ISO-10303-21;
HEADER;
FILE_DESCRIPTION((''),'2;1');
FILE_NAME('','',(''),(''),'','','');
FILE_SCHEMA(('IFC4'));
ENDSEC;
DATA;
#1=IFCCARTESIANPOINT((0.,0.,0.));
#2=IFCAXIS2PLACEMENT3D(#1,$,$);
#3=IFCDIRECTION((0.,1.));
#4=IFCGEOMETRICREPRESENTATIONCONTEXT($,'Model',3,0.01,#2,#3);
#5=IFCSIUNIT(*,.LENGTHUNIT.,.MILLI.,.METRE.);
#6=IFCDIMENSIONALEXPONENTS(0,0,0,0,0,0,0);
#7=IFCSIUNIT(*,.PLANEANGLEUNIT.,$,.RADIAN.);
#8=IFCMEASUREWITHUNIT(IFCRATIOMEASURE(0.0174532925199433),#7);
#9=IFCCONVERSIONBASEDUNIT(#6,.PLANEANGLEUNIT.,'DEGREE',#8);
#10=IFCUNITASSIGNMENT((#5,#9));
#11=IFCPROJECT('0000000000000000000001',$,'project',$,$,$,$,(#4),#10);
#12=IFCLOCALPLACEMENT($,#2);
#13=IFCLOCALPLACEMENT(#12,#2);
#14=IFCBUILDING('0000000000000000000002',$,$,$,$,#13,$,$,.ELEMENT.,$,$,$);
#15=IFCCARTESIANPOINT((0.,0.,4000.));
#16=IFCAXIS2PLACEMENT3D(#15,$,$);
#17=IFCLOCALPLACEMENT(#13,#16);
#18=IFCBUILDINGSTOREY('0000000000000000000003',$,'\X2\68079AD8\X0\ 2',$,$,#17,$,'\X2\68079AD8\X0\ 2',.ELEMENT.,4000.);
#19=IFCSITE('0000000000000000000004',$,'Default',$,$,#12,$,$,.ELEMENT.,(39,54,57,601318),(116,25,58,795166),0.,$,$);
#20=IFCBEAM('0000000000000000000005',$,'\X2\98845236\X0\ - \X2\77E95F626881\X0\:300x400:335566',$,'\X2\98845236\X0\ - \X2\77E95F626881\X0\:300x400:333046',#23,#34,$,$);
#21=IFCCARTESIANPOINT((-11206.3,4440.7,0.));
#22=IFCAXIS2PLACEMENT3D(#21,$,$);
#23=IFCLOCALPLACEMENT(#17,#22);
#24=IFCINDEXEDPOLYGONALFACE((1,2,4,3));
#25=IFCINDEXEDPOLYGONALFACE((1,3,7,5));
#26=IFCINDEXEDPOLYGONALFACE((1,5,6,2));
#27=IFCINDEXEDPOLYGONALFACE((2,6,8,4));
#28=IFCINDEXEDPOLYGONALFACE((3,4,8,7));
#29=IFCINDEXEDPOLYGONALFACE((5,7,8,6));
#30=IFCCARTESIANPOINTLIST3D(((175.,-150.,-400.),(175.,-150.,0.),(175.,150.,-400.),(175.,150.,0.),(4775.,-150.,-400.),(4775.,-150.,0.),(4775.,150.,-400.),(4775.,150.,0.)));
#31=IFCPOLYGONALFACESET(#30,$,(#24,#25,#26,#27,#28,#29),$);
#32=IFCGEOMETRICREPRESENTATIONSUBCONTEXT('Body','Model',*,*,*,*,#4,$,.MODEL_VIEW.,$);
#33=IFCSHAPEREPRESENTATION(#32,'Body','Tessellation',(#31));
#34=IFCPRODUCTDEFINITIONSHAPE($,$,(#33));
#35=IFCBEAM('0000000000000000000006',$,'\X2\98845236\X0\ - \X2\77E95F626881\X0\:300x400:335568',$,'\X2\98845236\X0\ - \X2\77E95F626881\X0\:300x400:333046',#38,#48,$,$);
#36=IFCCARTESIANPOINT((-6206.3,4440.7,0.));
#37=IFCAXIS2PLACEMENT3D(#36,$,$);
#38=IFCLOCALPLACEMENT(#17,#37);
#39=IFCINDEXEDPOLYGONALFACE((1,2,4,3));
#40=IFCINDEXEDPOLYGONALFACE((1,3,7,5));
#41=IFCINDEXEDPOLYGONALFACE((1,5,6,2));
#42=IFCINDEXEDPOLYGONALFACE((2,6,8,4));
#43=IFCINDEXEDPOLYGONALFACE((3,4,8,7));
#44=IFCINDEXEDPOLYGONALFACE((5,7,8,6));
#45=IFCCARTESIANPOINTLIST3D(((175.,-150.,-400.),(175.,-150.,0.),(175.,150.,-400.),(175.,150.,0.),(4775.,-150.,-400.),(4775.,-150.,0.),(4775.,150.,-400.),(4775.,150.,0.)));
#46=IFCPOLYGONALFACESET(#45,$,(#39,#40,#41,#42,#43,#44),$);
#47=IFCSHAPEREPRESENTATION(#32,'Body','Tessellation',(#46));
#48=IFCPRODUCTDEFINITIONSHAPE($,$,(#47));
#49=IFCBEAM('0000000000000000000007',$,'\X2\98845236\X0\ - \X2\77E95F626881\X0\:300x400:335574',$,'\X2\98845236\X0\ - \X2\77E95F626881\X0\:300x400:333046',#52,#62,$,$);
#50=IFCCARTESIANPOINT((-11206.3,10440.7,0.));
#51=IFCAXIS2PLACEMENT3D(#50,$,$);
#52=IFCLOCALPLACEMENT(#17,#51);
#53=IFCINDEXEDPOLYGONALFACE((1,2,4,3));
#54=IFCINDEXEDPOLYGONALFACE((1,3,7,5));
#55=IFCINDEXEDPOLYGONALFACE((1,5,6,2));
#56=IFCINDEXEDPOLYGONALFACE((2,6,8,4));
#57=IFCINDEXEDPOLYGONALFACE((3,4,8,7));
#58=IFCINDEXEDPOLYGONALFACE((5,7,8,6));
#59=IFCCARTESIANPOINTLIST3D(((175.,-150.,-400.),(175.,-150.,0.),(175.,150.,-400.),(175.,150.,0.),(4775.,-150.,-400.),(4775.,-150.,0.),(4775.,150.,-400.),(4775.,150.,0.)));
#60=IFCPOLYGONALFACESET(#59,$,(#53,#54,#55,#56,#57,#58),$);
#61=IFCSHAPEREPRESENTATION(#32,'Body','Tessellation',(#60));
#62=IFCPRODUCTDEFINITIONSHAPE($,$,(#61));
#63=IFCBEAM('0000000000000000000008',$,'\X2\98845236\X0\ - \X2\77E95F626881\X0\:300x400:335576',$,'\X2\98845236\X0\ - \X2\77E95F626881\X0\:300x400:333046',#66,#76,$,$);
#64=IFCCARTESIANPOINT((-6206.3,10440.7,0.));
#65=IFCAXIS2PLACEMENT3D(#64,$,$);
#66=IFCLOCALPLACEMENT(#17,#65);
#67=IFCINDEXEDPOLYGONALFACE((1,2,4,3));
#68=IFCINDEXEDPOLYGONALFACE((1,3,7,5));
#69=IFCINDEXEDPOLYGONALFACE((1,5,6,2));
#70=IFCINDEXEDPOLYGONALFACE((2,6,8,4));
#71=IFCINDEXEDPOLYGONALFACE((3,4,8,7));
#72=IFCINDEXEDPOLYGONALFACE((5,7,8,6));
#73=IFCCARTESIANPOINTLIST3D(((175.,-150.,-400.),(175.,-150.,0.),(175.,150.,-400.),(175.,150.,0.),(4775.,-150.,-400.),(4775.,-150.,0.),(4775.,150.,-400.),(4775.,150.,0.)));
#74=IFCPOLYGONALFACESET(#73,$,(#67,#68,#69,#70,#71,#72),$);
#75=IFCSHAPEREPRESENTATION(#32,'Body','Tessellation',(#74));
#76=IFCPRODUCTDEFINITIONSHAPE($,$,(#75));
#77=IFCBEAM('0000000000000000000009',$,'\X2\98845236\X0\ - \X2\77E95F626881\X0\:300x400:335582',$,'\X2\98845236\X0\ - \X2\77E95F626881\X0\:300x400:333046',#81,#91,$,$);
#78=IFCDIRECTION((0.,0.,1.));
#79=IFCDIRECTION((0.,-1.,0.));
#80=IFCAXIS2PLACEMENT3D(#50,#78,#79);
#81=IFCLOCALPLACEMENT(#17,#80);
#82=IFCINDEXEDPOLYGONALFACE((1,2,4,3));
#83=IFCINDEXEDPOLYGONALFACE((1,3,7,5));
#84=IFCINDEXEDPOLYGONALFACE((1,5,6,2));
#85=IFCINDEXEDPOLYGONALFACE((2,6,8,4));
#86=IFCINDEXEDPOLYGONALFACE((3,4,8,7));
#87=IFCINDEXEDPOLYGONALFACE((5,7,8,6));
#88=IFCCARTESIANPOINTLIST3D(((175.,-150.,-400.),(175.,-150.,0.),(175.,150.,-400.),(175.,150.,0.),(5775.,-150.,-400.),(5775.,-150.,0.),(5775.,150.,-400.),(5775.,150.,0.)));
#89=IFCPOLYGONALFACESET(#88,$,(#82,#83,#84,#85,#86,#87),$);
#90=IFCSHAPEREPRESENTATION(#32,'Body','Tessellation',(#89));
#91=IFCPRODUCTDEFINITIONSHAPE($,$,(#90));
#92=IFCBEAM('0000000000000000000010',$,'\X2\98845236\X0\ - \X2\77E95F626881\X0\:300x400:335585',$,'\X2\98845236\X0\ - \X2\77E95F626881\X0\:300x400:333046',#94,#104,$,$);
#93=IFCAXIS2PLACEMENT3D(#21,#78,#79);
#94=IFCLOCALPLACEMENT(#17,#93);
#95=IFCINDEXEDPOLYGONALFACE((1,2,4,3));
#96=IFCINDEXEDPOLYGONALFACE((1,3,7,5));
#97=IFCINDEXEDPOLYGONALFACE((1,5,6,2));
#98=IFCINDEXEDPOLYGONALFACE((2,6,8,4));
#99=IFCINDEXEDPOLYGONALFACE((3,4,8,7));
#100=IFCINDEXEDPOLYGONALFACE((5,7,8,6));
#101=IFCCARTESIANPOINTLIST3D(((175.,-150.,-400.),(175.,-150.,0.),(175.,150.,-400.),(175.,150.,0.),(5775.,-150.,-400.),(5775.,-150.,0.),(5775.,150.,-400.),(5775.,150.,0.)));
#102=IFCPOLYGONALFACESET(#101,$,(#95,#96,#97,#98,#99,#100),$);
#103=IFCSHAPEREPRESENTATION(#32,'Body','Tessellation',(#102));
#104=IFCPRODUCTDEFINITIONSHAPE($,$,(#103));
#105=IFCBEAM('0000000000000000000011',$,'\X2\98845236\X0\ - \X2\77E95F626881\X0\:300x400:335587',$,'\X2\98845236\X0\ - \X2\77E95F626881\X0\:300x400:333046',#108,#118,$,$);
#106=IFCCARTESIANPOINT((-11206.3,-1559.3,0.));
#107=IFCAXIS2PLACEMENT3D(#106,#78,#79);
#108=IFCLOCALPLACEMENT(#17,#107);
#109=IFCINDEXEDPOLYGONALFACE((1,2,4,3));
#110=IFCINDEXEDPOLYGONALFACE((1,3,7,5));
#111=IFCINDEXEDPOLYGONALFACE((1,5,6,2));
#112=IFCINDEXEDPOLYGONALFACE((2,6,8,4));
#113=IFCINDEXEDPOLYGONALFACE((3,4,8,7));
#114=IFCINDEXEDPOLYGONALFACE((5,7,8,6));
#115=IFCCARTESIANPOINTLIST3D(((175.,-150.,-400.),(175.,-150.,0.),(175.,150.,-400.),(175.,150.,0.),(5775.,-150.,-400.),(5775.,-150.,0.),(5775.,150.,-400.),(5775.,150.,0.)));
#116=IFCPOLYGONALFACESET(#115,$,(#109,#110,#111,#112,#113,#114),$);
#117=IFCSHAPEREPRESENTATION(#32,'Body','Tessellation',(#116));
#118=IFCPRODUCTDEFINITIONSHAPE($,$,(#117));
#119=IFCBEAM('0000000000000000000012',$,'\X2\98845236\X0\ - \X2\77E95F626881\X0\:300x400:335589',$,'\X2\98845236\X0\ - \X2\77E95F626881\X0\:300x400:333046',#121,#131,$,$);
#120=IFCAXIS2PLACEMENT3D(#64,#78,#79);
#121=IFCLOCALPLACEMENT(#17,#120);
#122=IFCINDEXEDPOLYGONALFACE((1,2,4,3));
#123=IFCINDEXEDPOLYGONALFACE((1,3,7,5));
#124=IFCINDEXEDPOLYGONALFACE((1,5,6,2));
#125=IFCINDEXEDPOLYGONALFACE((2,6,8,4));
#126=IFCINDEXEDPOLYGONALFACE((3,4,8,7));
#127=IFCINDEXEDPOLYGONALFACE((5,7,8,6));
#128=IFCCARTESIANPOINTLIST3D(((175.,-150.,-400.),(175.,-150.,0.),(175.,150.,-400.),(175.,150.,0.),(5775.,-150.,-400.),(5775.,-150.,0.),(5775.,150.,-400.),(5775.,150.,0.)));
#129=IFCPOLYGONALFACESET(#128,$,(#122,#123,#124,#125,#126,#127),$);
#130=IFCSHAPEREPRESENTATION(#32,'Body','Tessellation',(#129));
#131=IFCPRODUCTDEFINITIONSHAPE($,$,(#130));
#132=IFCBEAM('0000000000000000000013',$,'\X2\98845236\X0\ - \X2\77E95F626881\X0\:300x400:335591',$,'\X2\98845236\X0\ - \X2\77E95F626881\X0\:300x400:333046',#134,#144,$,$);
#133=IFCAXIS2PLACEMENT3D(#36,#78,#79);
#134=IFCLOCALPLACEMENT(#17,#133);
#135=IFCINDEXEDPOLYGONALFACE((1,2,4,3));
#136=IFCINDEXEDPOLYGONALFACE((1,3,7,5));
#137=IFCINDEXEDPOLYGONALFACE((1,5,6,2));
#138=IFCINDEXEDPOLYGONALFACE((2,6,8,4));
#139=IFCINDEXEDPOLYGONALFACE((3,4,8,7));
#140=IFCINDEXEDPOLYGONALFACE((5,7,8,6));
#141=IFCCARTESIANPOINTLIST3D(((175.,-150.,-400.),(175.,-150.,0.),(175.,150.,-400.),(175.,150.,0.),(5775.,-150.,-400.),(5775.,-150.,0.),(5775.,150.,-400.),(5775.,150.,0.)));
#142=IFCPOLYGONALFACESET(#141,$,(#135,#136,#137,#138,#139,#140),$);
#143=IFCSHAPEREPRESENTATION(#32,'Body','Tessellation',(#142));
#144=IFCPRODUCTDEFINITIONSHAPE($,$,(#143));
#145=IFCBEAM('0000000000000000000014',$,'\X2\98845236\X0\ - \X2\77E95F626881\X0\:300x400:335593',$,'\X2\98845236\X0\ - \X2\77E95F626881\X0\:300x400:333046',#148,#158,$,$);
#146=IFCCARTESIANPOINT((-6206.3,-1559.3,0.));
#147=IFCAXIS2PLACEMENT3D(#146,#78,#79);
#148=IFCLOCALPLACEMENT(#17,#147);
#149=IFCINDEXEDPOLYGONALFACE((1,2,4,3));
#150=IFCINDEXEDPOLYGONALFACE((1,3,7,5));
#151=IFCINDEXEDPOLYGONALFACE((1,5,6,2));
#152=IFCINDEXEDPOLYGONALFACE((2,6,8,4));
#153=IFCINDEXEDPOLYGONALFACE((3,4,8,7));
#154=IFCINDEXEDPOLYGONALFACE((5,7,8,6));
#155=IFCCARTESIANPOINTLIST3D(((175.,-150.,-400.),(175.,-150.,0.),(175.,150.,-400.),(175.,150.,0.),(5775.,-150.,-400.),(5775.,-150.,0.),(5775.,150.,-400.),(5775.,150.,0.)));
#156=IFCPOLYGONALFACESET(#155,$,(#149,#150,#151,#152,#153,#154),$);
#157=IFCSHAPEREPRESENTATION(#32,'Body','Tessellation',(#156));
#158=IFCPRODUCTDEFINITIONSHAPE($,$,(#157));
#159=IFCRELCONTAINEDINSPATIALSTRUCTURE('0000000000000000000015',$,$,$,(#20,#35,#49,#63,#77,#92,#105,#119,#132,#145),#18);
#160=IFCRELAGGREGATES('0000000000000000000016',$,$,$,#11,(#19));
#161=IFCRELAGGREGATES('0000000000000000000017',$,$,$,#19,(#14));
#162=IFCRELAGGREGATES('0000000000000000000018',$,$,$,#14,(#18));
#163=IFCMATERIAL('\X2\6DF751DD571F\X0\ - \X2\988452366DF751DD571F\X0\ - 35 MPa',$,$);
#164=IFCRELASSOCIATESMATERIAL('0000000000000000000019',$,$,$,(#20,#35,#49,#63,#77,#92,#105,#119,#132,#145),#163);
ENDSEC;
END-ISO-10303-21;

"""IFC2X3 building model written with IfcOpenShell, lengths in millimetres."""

from ifc_helpers import new_model, entity, si_unit, converted_unit, direction, frame, frame_2d, origin, place, context, subcontext, project, spatial, rectangle, extrude, material, element, save


model = new_model("IFC2X3")

# Units and contexts
model_context = context("Model", 3, precision=0.01, world=origin(), true_north=direction((0.0, 1.0)))
body_context = subcontext(model_context, "Body", "Model", "MODEL_VIEW")
ifc_project = project(units=[si_unit("LENGTHUNIT", "METRE", prefix="MILLI"), converted_unit("PLANEANGLEUNIT", "DEGREE", entity("IfcRatioMeasure", 0.0174532925199433), si_unit("PLANEANGLEUNIT", "RADIAN"), dimensions=[0, 0, 0, 0, 0, 0, 0])], contexts=[model_context])

# Site, building, storey
site_placement = place(None, origin())
site = spatial("IfcSite", under=ifc_project, at=site_placement, Name="Default", CompositionType="ELEMENT", RefLatitude=(39, 54, 57, 601318), RefLongitude=(116, 25, 58, 795166), RefElevation=0.0)
building_placement = place(site_placement, origin())
building = spatial("IfcBuilding", under=site, at=building_placement, CompositionType="ELEMENT")
storey_placement = place(building_placement, frame((0.0, 0.0, 4000.0)))
storey = spatial("IfcBuildingStorey", under=building, at=storey_placement, Name="标高 2", LongName="标高 2", CompositionType="ELEMENT", Elevation=4000.0)

# Shared definitions
ifc_material = material(Name="混凝土 - 预制混凝土 - 35 MPa")

# Beams
beam_1_placement = place(storey_placement, frame((-11206.3, 4440.7, 0.0)))
element("IfcBeam", 1, at=beam_1_placement, inside=storey, material=ifc_material, Name="预制 - 矩形梁:300x400:335566", ObjectType="预制 - 矩形梁:300x400:333046", context=body_context, shape_type="SweptSolid", body=[
    extrude(rectangle(XDim=400.0, YDim=300.0, at=frame_2d((0.0, 0.0), x_axis=(1.0, 0.0))), frame((175.0, 0.0, -200.0), z_axis=(1.0, 0.0, 0.0), x_axis=(0.0, 0.0, -1.0)), (0.0, 0.0, 1.0), 4600.0),
])
beam_2_placement = place(storey_placement, frame((-6206.3, 4440.7, 0.0)))
element("IfcBeam", 2, at=beam_2_placement, inside=storey, material=ifc_material, Name="预制 - 矩形梁:300x400:335568", ObjectType="预制 - 矩形梁:300x400:333046", context=body_context, shape_type="SweptSolid", body=[
    extrude(rectangle(XDim=400.0, YDim=300.0, at=frame_2d((0.0, 0.0), x_axis=(1.0, 0.0))), frame((175.0, 0.0, -200.0), z_axis=(1.0, 0.0, 0.0), x_axis=(0.0, 0.0, -1.0)), (0.0, 0.0, 1.0), 4600.0),
])
beam_3_placement = place(storey_placement, frame((-11206.3, 10440.7, 0.0)))
element("IfcBeam", 3, at=beam_3_placement, inside=storey, material=ifc_material, Name="预制 - 矩形梁:300x400:335574", ObjectType="预制 - 矩形梁:300x400:333046", context=body_context, shape_type="SweptSolid", body=[
    extrude(rectangle(XDim=400.0, YDim=300.0, at=frame_2d((0.0, 0.0), x_axis=(1.0, 0.0))), frame((175.0, 0.0, -200.0), z_axis=(1.0, 0.0, 0.0), x_axis=(0.0, 0.0, -1.0)), (0.0, 0.0, 1.0), 4600.0),
])
beam_4_placement = place(storey_placement, frame((-6206.3, 10440.7, 0.0)))
element("IfcBeam", 4, at=beam_4_placement, inside=storey, material=ifc_material, Name="预制 - 矩形梁:300x400:335576", ObjectType="预制 - 矩形梁:300x400:333046", context=body_context, shape_type="SweptSolid", body=[
    extrude(rectangle(XDim=400.0, YDim=300.0, at=frame_2d((0.0, 0.0), x_axis=(1.0, 0.0))), frame((175.0, 0.0, -200.0), z_axis=(1.0, 0.0, 0.0), x_axis=(0.0, 0.0, -1.0)), (0.0, 0.0, 1.0), 4600.0),
])
for number, where, z_axis, x_axis, name in (
    (5, (-11206.3, 10440.7, 0.0), (0.0, 0.0, 1.0), (0.0, -1.0, 0.0), "预制 - 矩形梁:300x400:335582"),
    (6, (-11206.3, 4440.7, 0.0), (0.0, 0.0, 1.0), (0.0, -1.0, 0.0), "预制 - 矩形梁:300x400:335585"),
):
    element("IfcBeam", number, at=place(storey_placement, frame(where, z_axis=z_axis, x_axis=x_axis)), inside=storey, material=ifc_material, Name=name, ObjectType="预制 - 矩形梁:300x400:333046", context=body_context, shape_type="SweptSolid", body=[
        extrude(rectangle(XDim=400.0, YDim=300.0, at=frame_2d((0.0, 0.0), x_axis=(1.0, 0.0))), frame((175.0, 0.0, -200.0), z_axis=(1.0, 0.0, 0.0), x_axis=(0.0, 0.0, -1.0)), (0.0, 0.0, 1.0), 5600.0),
    ])
beam_5_placement = place(storey_placement, frame((-11206.3, -1559.3, 0.0), z_axis=(0.0, 0.0, 1.0), x_axis=(0.0, -1.0, 0.0)))
element("IfcBeam", 7, at=beam_5_placement, inside=storey, material=ifc_material, Name="预制 - 矩形梁:300x400:335587", ObjectType="预制 - 矩形梁:300x400:333046", context=body_context, shape_type="SweptSolid", body=[
    extrude(rectangle(XDim=400.0, YDim=300.0, at=frame_2d((0.0, 0.0), x_axis=(1.0, 0.0))), frame((175.0, 0.0, -200.0), z_axis=(1.0, 0.0, 0.0), x_axis=(0.0, 0.0, -1.0)), (0.0, 0.0, 1.0), 5600.0),
])
for number, where, z_axis, x_axis, name in (
    (8, (-6206.3, 10440.7, 0.0), (0.0, 0.0, 1.0), (0.0, -1.0, 0.0), "预制 - 矩形梁:300x400:335589"),
    (9, (-6206.3, 4440.7, 0.0), (0.0, 0.0, 1.0), (0.0, -1.0, 0.0), "预制 - 矩形梁:300x400:335591"),
    (10, (-6206.3, -1559.3, 0.0), (0.0, 0.0, 1.0), (0.0, -1.0, 0.0), "预制 - 矩形梁:300x400:335593"),
):
    element("IfcBeam", number, at=place(storey_placement, frame(where, z_axis=z_axis, x_axis=x_axis)), inside=storey, material=ifc_material, Name=name, ObjectType="预制 - 矩形梁:300x400:333046", context=body_context, shape_type="SweptSolid", body=[
        extrude(rectangle(XDim=400.0, YDim=300.0, at=frame_2d((0.0, 0.0), x_axis=(1.0, 0.0))), frame((175.0, 0.0, -200.0), z_axis=(1.0, 0.0, 0.0), x_axis=(0.0, 0.0, -1.0)), (0.0, 0.0, 1.0), 5600.0),
    ])

save(model, "model.ifc")
